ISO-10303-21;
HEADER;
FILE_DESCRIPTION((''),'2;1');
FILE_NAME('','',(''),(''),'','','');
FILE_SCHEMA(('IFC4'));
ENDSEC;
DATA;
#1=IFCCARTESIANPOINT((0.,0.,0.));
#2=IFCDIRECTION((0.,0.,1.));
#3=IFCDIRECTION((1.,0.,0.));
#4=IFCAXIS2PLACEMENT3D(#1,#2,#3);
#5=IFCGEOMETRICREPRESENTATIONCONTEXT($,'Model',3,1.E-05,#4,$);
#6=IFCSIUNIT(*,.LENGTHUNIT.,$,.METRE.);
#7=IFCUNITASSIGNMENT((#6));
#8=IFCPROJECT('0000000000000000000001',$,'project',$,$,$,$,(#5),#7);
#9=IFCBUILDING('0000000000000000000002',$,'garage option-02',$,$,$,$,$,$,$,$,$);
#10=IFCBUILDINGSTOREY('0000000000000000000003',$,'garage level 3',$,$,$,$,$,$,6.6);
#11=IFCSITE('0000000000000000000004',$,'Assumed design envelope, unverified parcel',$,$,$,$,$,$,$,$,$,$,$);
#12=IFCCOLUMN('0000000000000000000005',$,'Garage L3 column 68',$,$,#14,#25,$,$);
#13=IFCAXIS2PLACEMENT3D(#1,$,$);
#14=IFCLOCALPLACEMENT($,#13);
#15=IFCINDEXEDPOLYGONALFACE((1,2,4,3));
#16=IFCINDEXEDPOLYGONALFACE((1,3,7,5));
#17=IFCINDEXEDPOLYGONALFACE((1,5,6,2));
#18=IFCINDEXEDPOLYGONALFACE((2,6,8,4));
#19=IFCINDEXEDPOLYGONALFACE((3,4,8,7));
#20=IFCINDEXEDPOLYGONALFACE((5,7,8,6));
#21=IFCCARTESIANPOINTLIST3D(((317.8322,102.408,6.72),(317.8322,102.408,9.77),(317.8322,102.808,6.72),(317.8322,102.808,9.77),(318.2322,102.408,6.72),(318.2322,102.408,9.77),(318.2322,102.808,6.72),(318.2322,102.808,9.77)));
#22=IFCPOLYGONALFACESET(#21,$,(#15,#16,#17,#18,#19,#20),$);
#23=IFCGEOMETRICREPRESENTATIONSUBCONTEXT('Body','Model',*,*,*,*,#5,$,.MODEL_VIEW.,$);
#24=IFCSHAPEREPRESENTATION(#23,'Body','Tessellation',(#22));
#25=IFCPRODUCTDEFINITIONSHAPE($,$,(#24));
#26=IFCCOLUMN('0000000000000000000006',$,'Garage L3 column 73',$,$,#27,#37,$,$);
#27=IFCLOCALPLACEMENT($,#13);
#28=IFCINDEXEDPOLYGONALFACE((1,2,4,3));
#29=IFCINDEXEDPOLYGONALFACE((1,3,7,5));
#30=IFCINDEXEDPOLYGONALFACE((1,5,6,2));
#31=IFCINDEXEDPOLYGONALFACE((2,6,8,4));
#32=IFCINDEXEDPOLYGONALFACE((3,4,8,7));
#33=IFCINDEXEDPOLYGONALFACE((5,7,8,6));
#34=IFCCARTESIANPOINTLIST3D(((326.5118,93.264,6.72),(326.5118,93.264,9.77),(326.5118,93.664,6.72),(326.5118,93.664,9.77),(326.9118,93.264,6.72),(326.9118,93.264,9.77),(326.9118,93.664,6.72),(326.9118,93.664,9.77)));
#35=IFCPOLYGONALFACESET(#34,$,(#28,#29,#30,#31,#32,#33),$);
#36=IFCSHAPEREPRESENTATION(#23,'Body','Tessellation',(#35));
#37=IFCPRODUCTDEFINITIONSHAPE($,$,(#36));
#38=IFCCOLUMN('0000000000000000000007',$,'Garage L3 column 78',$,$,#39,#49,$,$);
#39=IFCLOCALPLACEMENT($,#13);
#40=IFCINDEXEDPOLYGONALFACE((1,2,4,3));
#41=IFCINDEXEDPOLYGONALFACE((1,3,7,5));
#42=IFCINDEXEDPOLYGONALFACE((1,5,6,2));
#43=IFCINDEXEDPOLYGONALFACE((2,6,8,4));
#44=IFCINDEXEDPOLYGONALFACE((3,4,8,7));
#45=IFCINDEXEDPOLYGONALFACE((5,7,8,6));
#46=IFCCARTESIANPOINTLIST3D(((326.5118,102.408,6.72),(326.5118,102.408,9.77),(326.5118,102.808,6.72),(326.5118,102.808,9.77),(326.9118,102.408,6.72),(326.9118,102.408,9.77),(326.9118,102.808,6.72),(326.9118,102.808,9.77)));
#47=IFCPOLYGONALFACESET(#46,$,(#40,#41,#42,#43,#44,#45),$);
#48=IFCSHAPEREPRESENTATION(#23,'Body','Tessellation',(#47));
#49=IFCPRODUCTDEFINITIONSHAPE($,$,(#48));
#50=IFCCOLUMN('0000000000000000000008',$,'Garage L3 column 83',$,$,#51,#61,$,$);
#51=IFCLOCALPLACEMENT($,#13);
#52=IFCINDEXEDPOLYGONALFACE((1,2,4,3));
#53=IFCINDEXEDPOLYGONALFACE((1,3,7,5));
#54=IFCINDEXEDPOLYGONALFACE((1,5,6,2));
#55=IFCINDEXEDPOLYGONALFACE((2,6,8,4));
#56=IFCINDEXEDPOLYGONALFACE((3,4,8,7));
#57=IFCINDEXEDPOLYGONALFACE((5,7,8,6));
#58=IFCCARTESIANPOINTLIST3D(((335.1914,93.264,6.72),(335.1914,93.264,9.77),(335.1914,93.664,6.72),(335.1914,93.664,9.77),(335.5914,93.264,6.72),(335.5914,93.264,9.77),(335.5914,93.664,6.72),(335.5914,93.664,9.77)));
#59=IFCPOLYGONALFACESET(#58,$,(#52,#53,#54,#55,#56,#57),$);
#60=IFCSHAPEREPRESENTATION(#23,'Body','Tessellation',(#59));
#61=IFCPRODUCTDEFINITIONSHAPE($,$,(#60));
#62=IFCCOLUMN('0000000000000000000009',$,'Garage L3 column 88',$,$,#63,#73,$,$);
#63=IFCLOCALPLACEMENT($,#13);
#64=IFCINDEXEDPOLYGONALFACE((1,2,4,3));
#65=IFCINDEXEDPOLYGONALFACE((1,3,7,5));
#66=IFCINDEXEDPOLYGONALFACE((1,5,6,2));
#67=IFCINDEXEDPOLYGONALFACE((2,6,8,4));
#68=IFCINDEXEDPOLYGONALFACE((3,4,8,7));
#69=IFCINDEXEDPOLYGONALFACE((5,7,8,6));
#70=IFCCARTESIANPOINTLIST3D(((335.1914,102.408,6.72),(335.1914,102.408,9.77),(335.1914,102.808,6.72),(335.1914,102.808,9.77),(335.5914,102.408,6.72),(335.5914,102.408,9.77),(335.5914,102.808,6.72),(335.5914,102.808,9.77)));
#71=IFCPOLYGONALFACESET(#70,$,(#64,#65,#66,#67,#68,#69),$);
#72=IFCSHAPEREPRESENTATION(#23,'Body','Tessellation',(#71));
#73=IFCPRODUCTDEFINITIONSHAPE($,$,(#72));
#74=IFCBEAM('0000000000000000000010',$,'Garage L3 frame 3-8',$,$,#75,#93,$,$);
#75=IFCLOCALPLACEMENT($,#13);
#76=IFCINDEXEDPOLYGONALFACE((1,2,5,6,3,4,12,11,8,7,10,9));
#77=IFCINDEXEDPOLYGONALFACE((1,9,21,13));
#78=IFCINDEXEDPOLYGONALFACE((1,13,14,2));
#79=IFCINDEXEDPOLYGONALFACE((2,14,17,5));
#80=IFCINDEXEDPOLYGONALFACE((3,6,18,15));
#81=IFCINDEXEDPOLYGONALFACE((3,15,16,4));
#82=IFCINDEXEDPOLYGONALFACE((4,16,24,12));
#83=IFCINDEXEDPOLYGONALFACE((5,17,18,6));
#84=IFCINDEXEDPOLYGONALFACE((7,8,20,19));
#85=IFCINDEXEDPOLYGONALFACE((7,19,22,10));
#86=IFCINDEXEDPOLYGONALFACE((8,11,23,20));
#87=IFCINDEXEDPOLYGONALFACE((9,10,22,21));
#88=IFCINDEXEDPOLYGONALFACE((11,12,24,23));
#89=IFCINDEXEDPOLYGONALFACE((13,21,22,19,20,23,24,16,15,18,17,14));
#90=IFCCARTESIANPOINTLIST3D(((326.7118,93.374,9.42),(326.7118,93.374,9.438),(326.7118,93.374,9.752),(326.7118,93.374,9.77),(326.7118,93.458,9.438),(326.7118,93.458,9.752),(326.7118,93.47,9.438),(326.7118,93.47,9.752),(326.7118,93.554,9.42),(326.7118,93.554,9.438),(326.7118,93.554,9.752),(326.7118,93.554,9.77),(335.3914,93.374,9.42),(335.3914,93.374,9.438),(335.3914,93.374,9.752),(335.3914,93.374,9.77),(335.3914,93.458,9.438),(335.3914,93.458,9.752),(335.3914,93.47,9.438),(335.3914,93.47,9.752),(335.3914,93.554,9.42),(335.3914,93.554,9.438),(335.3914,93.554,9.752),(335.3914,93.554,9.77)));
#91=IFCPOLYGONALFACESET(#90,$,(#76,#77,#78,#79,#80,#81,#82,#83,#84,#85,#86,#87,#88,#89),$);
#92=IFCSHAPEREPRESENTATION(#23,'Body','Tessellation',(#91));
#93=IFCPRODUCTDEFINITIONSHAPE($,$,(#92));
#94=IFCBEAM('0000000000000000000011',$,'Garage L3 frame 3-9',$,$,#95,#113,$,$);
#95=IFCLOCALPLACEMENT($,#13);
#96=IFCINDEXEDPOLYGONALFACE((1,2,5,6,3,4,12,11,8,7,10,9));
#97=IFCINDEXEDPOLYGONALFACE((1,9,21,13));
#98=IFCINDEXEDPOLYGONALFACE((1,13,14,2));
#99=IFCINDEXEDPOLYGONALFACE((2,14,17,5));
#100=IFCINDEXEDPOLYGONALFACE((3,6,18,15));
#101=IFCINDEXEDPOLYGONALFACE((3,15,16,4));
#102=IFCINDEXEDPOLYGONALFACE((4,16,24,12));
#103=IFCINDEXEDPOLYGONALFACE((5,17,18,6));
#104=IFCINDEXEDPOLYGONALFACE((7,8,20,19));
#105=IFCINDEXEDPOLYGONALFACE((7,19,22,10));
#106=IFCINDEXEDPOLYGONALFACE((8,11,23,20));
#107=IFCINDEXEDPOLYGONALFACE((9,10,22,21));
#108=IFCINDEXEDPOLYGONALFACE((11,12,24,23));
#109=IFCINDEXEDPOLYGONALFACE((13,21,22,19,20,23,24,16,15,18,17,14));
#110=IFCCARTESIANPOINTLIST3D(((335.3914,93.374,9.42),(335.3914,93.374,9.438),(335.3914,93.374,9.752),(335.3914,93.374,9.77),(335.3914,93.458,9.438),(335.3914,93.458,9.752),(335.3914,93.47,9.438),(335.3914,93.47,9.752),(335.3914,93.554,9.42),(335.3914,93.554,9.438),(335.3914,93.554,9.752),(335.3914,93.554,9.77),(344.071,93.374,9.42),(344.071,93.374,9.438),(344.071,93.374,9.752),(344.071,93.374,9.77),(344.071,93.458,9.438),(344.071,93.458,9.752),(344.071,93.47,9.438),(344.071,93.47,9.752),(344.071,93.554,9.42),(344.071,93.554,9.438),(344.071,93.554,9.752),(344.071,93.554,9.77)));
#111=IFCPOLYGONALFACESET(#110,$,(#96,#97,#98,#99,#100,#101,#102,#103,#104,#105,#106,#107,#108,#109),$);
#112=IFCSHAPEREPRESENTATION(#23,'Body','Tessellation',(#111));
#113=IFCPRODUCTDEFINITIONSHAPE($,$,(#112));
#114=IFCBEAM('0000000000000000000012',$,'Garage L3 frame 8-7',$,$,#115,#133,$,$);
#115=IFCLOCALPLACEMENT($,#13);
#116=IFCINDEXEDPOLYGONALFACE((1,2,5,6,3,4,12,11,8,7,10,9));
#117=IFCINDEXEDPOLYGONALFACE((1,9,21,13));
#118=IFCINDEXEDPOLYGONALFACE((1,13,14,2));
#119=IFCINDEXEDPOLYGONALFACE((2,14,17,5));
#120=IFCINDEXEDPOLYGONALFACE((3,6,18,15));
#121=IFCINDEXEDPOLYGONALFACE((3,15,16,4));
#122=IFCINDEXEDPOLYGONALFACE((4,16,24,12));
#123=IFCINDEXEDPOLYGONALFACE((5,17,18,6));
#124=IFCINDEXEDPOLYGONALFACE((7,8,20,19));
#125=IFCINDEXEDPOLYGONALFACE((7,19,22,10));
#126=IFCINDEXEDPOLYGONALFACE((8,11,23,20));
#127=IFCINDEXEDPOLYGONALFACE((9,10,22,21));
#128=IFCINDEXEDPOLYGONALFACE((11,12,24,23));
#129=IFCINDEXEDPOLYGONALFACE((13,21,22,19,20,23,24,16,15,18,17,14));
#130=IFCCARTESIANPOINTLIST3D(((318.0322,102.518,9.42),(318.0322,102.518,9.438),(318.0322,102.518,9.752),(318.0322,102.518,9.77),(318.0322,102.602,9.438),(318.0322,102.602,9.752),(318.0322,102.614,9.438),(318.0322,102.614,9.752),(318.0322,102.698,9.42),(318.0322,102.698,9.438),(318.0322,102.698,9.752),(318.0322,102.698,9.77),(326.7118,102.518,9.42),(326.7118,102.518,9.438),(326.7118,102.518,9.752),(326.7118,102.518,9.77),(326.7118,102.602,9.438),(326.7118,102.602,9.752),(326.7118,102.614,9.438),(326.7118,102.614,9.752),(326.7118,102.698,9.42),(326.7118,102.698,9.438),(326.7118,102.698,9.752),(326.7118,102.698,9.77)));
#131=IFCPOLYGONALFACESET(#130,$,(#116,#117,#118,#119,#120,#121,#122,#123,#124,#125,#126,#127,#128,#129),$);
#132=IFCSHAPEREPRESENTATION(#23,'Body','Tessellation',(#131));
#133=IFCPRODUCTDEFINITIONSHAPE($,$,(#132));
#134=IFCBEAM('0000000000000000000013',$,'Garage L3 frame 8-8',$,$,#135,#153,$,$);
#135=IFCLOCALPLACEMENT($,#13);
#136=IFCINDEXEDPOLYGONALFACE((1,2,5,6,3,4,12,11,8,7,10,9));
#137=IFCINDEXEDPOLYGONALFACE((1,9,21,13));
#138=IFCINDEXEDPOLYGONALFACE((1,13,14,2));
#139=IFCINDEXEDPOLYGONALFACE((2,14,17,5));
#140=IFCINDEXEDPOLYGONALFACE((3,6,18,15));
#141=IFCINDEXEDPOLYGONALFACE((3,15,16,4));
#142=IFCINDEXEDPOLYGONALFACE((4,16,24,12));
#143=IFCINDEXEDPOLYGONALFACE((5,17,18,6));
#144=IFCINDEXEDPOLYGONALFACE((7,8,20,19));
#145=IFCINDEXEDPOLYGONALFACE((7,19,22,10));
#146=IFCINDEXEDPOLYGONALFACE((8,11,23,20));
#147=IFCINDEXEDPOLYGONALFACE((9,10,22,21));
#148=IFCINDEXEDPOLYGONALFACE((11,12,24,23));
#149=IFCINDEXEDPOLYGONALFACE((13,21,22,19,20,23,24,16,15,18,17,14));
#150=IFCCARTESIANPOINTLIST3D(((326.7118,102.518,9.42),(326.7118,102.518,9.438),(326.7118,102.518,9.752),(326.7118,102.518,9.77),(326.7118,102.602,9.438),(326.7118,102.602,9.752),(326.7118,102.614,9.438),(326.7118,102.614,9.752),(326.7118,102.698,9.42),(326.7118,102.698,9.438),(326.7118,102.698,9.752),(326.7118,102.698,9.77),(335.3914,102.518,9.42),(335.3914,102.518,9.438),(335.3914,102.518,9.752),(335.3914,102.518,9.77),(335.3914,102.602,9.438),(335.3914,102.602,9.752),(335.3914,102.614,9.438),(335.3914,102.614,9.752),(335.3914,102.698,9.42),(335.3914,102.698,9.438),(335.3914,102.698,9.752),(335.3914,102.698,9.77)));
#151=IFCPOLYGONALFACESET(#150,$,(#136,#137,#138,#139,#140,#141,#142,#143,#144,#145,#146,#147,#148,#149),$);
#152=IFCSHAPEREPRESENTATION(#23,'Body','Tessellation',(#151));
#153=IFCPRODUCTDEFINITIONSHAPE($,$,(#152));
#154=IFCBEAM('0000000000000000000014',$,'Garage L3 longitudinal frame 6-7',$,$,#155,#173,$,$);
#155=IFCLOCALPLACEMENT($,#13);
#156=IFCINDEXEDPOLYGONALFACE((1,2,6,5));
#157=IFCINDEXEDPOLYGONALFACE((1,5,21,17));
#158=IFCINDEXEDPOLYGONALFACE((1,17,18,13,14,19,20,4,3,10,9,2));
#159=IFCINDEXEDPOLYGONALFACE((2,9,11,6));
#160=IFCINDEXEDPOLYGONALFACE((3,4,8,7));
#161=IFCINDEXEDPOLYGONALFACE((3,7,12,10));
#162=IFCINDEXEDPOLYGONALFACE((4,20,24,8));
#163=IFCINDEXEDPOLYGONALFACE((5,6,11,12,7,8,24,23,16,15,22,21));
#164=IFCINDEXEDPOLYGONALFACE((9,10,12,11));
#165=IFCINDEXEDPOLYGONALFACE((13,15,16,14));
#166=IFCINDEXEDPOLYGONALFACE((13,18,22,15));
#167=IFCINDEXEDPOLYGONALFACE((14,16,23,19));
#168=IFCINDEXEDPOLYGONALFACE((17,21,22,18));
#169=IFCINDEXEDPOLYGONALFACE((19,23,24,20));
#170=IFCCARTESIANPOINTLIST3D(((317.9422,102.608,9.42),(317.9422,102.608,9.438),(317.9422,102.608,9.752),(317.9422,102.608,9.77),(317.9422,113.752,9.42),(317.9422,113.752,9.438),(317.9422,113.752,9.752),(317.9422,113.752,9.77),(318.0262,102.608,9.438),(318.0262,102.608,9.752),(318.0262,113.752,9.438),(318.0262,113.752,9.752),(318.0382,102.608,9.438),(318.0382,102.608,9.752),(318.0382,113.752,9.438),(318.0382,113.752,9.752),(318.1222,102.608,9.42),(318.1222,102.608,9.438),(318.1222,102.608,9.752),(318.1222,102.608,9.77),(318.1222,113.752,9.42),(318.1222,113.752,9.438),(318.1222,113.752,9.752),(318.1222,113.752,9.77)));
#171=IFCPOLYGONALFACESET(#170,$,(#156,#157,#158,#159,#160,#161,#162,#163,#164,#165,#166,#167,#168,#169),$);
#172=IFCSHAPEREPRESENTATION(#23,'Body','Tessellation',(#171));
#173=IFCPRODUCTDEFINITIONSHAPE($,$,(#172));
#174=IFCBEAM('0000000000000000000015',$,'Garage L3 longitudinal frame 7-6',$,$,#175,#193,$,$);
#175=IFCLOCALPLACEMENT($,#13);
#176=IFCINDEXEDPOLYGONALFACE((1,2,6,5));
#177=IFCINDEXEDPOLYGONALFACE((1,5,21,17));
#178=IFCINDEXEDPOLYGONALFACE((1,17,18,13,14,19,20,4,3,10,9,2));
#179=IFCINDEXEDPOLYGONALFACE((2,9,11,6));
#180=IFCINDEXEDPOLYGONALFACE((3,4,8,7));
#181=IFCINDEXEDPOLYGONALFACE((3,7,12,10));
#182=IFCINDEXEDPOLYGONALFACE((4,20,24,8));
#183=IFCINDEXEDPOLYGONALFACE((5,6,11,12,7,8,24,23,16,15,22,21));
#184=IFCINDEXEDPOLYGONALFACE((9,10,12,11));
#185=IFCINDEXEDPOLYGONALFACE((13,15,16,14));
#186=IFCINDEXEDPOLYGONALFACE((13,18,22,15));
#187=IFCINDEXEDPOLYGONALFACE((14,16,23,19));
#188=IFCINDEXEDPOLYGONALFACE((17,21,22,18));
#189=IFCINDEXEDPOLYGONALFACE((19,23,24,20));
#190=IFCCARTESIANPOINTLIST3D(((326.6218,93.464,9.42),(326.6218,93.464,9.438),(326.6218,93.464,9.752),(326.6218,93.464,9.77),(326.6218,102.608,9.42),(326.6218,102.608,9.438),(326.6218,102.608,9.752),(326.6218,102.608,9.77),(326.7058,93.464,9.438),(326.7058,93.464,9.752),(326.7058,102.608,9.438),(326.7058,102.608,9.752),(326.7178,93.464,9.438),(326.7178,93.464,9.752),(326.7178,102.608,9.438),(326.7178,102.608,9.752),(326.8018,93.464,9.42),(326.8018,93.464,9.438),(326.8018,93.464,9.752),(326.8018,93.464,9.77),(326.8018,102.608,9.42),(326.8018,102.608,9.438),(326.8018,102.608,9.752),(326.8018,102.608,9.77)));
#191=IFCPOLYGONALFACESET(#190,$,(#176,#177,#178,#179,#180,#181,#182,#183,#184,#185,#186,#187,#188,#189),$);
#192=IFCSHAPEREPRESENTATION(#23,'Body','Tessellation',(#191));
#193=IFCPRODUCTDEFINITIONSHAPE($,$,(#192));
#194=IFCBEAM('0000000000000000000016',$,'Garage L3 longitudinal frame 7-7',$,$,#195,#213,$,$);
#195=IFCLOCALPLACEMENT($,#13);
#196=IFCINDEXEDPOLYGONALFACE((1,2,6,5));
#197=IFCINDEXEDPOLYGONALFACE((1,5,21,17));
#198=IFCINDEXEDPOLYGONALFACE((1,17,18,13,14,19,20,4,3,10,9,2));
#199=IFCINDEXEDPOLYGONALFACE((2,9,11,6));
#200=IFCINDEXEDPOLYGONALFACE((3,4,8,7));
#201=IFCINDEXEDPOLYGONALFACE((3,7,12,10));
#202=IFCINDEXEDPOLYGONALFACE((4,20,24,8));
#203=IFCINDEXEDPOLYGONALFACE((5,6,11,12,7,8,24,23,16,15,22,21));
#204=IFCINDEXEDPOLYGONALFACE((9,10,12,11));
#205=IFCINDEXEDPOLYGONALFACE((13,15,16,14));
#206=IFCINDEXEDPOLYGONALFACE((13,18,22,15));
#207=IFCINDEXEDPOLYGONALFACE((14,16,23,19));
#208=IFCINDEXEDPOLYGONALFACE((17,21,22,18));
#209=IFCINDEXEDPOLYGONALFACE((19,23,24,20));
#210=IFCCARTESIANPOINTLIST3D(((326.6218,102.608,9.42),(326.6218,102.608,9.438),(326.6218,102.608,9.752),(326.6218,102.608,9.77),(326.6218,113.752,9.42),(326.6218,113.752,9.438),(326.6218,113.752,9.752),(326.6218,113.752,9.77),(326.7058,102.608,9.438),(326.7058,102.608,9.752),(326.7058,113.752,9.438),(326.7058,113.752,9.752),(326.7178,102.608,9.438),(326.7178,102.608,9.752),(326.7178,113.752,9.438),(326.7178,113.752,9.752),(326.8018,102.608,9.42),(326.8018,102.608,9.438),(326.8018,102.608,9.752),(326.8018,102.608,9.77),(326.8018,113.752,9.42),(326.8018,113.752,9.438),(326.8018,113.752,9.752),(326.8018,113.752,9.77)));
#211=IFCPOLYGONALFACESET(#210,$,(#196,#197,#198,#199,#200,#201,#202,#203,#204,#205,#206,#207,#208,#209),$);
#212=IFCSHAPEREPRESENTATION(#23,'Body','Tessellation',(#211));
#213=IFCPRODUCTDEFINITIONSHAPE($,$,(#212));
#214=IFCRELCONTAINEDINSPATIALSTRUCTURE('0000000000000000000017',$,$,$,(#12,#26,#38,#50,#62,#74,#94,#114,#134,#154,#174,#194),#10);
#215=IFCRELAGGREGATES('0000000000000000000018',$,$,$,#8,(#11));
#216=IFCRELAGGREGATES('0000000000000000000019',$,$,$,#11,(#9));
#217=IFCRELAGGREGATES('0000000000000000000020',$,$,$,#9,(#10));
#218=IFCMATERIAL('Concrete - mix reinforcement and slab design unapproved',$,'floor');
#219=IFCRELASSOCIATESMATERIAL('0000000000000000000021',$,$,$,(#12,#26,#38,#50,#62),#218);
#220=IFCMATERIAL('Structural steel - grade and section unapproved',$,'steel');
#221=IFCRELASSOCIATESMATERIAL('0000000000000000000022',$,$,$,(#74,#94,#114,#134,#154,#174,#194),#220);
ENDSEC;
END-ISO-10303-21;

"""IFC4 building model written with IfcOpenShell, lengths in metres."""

from ifc_helpers import new_model, si_unit, frame, origin_with_axes, place, context, subcontext, project, spatial, rectangle, i_section, extrude, material, element, save


model = new_model("IFC4")

# Units and contexts
model_context = context("Model", 3, precision=1e-05, world=origin_with_axes())
body_context = subcontext(model_context, "Body", "Model", "MODEL_VIEW")
ifc_project = project(units=[si_unit("LENGTHUNIT", "METRE")], contexts=[model_context])

# Site, building, storey
site = spatial("IfcSite", under=ifc_project, Name="Assumed design envelope, unverified parcel")
building = spatial("IfcBuilding", under=site, Name="garage option-02")
storey = spatial("IfcBuildingStorey", under=building, Name="garage level 3", Elevation=6.6)

# Columns
ifc_material_1 = material(Name="Concrete - mix reinforcement and slab design unapproved", Category="floor")
for number, where, z_axis, x_axis, name in (
    (1, (318.0322, 102.608, 6.72), (0.0, 0.0, 1.0), (1.0, 0.0, 0.0), "Garage L3 column 68"),
    (2, (326.7118, 93.464, 6.72), (0.0, 0.0, 1.0), (1.0, 0.0, 0.0), "Garage L3 column 73"),
    (3, (326.7118, 102.608, 6.72), (0.0, 0.0, 1.0), (1.0, 0.0, 0.0), "Garage L3 column 78"),
    (4, (335.3914, 93.464, 6.72), (0.0, 0.0, 1.0), (1.0, 0.0, 0.0), "Garage L3 column 83"),
    (5, (335.3914, 102.608, 6.72), (0.0, 0.0, 1.0), (1.0, 0.0, 0.0), "Garage L3 column 88"),
):
    element("IfcColumn", number, at=place(None, frame(where, z_axis=z_axis, x_axis=x_axis)), inside=storey, material=ifc_material_1, Name=name, context=body_context, shape_type="SweptSolid", body=[
        extrude(rectangle(XDim=0.4, YDim=0.4), origin_with_axes(), (0.0, 0.0, 1.0), 3.05),
    ])

# Beams
ifc_material_2 = material(Name="Structural steel - grade and section unapproved", Category="steel")
beam_1_placement = place(None, frame((326.7118, 93.464, 9.595), z_axis=(1.0, 0.0, 0.0), x_axis=(0.0, 1.0, 0.0)))
element("IfcBeam", 6, at=beam_1_placement, inside=storey, material=ifc_material_2, Name="Garage L3 frame 3-8", context=body_context, shape_type="SweptSolid", body=[
    extrude(i_section(OverallWidth=0.18, OverallDepth=0.35, WebThickness=0.012, FlangeThickness=0.018, FilletRadius=0.0), origin_with_axes(), (0.0, 0.0, 1.0), 8.6796),
])
beam_2_placement = place(None, frame((335.3914, 93.464, 9.595), z_axis=(1.0, 0.0, 0.0), x_axis=(0.0, 1.0, 0.0)))
element("IfcBeam", 7, at=beam_2_placement, inside=storey, material=ifc_material_2, Name="Garage L3 frame 3-9", context=body_context, shape_type="SweptSolid", body=[
    extrude(i_section(OverallWidth=0.18, OverallDepth=0.35, WebThickness=0.012, FlangeThickness=0.018, FilletRadius=0.0), origin_with_axes(), (0.0, 0.0, 1.0), 8.6796),
])
for number, where, z_axis, x_axis, name in (
    (8, (318.0322, 102.608, 9.595), (1.0, 0.0, 0.0), (0.0, 1.0, 0.0), "Garage L3 frame 8-7"),
    (9, (326.7118, 102.608, 9.595), (1.0, 0.0, 0.0), (0.0, 1.0, 0.0), "Garage L3 frame 8-8"),
):
    element("IfcBeam", number, at=place(None, frame(where, z_axis=z_axis, x_axis=x_axis)), inside=storey, material=ifc_material_2, Name=name, context=body_context, shape_type="SweptSolid", body=[
        extrude(i_section(OverallWidth=0.18, OverallDepth=0.35, WebThickness=0.012, FlangeThickness=0.018, FilletRadius=0.0), origin_with_axes(), (0.0, 0.0, 1.0), 8.6796),
    ])
beam_3_placement = place(None, frame((318.0322, 102.608, 9.595), z_axis=(0.0, 1.0, 0.0), x_axis=(-1.0, 0.0, 0.0)))
element("IfcBeam", 10, at=beam_3_placement, inside=storey, material=ifc_material_2, Name="Garage L3 longitudinal frame 6-7", context=body_context, shape_type="SweptSolid", body=[
    extrude(i_section(OverallWidth=0.18, OverallDepth=0.35, WebThickness=0.012, FlangeThickness=0.018, FilletRadius=0.0), origin_with_axes(), (0.0, 0.0, 1.0), 11.144),
])
beam_4_placement = place(None, frame((326.7118, 93.464, 9.595), z_axis=(0.0, 1.0, 0.0), x_axis=(-1.0, 0.0, 0.0)))
element("IfcBeam", 11, at=beam_4_placement, inside=storey, material=ifc_material_2, Name="Garage L3 longitudinal frame 7-6", context=body_context, shape_type="SweptSolid", body=[
    extrude(i_section(OverallWidth=0.18, OverallDepth=0.35, WebThickness=0.012, FlangeThickness=0.018, FilletRadius=0.0), origin_with_axes(), (0.0, 0.0, 1.0), 9.144),
])
beam_5_placement = place(None, frame((326.7118, 102.608, 9.595), z_axis=(0.0, 1.0, 0.0), x_axis=(-1.0, 0.0, 0.0)))
element("IfcBeam", 12, at=beam_5_placement, inside=storey, material=ifc_material_2, Name="Garage L3 longitudinal frame 7-7", context=body_context, shape_type="SweptSolid", body=[
    extrude(i_section(OverallWidth=0.18, OverallDepth=0.35, WebThickness=0.012, FlangeThickness=0.018, FilletRadius=0.0), origin_with_axes(), (0.0, 0.0, 1.0), 11.144),
])

save(model, "model.ifc")
